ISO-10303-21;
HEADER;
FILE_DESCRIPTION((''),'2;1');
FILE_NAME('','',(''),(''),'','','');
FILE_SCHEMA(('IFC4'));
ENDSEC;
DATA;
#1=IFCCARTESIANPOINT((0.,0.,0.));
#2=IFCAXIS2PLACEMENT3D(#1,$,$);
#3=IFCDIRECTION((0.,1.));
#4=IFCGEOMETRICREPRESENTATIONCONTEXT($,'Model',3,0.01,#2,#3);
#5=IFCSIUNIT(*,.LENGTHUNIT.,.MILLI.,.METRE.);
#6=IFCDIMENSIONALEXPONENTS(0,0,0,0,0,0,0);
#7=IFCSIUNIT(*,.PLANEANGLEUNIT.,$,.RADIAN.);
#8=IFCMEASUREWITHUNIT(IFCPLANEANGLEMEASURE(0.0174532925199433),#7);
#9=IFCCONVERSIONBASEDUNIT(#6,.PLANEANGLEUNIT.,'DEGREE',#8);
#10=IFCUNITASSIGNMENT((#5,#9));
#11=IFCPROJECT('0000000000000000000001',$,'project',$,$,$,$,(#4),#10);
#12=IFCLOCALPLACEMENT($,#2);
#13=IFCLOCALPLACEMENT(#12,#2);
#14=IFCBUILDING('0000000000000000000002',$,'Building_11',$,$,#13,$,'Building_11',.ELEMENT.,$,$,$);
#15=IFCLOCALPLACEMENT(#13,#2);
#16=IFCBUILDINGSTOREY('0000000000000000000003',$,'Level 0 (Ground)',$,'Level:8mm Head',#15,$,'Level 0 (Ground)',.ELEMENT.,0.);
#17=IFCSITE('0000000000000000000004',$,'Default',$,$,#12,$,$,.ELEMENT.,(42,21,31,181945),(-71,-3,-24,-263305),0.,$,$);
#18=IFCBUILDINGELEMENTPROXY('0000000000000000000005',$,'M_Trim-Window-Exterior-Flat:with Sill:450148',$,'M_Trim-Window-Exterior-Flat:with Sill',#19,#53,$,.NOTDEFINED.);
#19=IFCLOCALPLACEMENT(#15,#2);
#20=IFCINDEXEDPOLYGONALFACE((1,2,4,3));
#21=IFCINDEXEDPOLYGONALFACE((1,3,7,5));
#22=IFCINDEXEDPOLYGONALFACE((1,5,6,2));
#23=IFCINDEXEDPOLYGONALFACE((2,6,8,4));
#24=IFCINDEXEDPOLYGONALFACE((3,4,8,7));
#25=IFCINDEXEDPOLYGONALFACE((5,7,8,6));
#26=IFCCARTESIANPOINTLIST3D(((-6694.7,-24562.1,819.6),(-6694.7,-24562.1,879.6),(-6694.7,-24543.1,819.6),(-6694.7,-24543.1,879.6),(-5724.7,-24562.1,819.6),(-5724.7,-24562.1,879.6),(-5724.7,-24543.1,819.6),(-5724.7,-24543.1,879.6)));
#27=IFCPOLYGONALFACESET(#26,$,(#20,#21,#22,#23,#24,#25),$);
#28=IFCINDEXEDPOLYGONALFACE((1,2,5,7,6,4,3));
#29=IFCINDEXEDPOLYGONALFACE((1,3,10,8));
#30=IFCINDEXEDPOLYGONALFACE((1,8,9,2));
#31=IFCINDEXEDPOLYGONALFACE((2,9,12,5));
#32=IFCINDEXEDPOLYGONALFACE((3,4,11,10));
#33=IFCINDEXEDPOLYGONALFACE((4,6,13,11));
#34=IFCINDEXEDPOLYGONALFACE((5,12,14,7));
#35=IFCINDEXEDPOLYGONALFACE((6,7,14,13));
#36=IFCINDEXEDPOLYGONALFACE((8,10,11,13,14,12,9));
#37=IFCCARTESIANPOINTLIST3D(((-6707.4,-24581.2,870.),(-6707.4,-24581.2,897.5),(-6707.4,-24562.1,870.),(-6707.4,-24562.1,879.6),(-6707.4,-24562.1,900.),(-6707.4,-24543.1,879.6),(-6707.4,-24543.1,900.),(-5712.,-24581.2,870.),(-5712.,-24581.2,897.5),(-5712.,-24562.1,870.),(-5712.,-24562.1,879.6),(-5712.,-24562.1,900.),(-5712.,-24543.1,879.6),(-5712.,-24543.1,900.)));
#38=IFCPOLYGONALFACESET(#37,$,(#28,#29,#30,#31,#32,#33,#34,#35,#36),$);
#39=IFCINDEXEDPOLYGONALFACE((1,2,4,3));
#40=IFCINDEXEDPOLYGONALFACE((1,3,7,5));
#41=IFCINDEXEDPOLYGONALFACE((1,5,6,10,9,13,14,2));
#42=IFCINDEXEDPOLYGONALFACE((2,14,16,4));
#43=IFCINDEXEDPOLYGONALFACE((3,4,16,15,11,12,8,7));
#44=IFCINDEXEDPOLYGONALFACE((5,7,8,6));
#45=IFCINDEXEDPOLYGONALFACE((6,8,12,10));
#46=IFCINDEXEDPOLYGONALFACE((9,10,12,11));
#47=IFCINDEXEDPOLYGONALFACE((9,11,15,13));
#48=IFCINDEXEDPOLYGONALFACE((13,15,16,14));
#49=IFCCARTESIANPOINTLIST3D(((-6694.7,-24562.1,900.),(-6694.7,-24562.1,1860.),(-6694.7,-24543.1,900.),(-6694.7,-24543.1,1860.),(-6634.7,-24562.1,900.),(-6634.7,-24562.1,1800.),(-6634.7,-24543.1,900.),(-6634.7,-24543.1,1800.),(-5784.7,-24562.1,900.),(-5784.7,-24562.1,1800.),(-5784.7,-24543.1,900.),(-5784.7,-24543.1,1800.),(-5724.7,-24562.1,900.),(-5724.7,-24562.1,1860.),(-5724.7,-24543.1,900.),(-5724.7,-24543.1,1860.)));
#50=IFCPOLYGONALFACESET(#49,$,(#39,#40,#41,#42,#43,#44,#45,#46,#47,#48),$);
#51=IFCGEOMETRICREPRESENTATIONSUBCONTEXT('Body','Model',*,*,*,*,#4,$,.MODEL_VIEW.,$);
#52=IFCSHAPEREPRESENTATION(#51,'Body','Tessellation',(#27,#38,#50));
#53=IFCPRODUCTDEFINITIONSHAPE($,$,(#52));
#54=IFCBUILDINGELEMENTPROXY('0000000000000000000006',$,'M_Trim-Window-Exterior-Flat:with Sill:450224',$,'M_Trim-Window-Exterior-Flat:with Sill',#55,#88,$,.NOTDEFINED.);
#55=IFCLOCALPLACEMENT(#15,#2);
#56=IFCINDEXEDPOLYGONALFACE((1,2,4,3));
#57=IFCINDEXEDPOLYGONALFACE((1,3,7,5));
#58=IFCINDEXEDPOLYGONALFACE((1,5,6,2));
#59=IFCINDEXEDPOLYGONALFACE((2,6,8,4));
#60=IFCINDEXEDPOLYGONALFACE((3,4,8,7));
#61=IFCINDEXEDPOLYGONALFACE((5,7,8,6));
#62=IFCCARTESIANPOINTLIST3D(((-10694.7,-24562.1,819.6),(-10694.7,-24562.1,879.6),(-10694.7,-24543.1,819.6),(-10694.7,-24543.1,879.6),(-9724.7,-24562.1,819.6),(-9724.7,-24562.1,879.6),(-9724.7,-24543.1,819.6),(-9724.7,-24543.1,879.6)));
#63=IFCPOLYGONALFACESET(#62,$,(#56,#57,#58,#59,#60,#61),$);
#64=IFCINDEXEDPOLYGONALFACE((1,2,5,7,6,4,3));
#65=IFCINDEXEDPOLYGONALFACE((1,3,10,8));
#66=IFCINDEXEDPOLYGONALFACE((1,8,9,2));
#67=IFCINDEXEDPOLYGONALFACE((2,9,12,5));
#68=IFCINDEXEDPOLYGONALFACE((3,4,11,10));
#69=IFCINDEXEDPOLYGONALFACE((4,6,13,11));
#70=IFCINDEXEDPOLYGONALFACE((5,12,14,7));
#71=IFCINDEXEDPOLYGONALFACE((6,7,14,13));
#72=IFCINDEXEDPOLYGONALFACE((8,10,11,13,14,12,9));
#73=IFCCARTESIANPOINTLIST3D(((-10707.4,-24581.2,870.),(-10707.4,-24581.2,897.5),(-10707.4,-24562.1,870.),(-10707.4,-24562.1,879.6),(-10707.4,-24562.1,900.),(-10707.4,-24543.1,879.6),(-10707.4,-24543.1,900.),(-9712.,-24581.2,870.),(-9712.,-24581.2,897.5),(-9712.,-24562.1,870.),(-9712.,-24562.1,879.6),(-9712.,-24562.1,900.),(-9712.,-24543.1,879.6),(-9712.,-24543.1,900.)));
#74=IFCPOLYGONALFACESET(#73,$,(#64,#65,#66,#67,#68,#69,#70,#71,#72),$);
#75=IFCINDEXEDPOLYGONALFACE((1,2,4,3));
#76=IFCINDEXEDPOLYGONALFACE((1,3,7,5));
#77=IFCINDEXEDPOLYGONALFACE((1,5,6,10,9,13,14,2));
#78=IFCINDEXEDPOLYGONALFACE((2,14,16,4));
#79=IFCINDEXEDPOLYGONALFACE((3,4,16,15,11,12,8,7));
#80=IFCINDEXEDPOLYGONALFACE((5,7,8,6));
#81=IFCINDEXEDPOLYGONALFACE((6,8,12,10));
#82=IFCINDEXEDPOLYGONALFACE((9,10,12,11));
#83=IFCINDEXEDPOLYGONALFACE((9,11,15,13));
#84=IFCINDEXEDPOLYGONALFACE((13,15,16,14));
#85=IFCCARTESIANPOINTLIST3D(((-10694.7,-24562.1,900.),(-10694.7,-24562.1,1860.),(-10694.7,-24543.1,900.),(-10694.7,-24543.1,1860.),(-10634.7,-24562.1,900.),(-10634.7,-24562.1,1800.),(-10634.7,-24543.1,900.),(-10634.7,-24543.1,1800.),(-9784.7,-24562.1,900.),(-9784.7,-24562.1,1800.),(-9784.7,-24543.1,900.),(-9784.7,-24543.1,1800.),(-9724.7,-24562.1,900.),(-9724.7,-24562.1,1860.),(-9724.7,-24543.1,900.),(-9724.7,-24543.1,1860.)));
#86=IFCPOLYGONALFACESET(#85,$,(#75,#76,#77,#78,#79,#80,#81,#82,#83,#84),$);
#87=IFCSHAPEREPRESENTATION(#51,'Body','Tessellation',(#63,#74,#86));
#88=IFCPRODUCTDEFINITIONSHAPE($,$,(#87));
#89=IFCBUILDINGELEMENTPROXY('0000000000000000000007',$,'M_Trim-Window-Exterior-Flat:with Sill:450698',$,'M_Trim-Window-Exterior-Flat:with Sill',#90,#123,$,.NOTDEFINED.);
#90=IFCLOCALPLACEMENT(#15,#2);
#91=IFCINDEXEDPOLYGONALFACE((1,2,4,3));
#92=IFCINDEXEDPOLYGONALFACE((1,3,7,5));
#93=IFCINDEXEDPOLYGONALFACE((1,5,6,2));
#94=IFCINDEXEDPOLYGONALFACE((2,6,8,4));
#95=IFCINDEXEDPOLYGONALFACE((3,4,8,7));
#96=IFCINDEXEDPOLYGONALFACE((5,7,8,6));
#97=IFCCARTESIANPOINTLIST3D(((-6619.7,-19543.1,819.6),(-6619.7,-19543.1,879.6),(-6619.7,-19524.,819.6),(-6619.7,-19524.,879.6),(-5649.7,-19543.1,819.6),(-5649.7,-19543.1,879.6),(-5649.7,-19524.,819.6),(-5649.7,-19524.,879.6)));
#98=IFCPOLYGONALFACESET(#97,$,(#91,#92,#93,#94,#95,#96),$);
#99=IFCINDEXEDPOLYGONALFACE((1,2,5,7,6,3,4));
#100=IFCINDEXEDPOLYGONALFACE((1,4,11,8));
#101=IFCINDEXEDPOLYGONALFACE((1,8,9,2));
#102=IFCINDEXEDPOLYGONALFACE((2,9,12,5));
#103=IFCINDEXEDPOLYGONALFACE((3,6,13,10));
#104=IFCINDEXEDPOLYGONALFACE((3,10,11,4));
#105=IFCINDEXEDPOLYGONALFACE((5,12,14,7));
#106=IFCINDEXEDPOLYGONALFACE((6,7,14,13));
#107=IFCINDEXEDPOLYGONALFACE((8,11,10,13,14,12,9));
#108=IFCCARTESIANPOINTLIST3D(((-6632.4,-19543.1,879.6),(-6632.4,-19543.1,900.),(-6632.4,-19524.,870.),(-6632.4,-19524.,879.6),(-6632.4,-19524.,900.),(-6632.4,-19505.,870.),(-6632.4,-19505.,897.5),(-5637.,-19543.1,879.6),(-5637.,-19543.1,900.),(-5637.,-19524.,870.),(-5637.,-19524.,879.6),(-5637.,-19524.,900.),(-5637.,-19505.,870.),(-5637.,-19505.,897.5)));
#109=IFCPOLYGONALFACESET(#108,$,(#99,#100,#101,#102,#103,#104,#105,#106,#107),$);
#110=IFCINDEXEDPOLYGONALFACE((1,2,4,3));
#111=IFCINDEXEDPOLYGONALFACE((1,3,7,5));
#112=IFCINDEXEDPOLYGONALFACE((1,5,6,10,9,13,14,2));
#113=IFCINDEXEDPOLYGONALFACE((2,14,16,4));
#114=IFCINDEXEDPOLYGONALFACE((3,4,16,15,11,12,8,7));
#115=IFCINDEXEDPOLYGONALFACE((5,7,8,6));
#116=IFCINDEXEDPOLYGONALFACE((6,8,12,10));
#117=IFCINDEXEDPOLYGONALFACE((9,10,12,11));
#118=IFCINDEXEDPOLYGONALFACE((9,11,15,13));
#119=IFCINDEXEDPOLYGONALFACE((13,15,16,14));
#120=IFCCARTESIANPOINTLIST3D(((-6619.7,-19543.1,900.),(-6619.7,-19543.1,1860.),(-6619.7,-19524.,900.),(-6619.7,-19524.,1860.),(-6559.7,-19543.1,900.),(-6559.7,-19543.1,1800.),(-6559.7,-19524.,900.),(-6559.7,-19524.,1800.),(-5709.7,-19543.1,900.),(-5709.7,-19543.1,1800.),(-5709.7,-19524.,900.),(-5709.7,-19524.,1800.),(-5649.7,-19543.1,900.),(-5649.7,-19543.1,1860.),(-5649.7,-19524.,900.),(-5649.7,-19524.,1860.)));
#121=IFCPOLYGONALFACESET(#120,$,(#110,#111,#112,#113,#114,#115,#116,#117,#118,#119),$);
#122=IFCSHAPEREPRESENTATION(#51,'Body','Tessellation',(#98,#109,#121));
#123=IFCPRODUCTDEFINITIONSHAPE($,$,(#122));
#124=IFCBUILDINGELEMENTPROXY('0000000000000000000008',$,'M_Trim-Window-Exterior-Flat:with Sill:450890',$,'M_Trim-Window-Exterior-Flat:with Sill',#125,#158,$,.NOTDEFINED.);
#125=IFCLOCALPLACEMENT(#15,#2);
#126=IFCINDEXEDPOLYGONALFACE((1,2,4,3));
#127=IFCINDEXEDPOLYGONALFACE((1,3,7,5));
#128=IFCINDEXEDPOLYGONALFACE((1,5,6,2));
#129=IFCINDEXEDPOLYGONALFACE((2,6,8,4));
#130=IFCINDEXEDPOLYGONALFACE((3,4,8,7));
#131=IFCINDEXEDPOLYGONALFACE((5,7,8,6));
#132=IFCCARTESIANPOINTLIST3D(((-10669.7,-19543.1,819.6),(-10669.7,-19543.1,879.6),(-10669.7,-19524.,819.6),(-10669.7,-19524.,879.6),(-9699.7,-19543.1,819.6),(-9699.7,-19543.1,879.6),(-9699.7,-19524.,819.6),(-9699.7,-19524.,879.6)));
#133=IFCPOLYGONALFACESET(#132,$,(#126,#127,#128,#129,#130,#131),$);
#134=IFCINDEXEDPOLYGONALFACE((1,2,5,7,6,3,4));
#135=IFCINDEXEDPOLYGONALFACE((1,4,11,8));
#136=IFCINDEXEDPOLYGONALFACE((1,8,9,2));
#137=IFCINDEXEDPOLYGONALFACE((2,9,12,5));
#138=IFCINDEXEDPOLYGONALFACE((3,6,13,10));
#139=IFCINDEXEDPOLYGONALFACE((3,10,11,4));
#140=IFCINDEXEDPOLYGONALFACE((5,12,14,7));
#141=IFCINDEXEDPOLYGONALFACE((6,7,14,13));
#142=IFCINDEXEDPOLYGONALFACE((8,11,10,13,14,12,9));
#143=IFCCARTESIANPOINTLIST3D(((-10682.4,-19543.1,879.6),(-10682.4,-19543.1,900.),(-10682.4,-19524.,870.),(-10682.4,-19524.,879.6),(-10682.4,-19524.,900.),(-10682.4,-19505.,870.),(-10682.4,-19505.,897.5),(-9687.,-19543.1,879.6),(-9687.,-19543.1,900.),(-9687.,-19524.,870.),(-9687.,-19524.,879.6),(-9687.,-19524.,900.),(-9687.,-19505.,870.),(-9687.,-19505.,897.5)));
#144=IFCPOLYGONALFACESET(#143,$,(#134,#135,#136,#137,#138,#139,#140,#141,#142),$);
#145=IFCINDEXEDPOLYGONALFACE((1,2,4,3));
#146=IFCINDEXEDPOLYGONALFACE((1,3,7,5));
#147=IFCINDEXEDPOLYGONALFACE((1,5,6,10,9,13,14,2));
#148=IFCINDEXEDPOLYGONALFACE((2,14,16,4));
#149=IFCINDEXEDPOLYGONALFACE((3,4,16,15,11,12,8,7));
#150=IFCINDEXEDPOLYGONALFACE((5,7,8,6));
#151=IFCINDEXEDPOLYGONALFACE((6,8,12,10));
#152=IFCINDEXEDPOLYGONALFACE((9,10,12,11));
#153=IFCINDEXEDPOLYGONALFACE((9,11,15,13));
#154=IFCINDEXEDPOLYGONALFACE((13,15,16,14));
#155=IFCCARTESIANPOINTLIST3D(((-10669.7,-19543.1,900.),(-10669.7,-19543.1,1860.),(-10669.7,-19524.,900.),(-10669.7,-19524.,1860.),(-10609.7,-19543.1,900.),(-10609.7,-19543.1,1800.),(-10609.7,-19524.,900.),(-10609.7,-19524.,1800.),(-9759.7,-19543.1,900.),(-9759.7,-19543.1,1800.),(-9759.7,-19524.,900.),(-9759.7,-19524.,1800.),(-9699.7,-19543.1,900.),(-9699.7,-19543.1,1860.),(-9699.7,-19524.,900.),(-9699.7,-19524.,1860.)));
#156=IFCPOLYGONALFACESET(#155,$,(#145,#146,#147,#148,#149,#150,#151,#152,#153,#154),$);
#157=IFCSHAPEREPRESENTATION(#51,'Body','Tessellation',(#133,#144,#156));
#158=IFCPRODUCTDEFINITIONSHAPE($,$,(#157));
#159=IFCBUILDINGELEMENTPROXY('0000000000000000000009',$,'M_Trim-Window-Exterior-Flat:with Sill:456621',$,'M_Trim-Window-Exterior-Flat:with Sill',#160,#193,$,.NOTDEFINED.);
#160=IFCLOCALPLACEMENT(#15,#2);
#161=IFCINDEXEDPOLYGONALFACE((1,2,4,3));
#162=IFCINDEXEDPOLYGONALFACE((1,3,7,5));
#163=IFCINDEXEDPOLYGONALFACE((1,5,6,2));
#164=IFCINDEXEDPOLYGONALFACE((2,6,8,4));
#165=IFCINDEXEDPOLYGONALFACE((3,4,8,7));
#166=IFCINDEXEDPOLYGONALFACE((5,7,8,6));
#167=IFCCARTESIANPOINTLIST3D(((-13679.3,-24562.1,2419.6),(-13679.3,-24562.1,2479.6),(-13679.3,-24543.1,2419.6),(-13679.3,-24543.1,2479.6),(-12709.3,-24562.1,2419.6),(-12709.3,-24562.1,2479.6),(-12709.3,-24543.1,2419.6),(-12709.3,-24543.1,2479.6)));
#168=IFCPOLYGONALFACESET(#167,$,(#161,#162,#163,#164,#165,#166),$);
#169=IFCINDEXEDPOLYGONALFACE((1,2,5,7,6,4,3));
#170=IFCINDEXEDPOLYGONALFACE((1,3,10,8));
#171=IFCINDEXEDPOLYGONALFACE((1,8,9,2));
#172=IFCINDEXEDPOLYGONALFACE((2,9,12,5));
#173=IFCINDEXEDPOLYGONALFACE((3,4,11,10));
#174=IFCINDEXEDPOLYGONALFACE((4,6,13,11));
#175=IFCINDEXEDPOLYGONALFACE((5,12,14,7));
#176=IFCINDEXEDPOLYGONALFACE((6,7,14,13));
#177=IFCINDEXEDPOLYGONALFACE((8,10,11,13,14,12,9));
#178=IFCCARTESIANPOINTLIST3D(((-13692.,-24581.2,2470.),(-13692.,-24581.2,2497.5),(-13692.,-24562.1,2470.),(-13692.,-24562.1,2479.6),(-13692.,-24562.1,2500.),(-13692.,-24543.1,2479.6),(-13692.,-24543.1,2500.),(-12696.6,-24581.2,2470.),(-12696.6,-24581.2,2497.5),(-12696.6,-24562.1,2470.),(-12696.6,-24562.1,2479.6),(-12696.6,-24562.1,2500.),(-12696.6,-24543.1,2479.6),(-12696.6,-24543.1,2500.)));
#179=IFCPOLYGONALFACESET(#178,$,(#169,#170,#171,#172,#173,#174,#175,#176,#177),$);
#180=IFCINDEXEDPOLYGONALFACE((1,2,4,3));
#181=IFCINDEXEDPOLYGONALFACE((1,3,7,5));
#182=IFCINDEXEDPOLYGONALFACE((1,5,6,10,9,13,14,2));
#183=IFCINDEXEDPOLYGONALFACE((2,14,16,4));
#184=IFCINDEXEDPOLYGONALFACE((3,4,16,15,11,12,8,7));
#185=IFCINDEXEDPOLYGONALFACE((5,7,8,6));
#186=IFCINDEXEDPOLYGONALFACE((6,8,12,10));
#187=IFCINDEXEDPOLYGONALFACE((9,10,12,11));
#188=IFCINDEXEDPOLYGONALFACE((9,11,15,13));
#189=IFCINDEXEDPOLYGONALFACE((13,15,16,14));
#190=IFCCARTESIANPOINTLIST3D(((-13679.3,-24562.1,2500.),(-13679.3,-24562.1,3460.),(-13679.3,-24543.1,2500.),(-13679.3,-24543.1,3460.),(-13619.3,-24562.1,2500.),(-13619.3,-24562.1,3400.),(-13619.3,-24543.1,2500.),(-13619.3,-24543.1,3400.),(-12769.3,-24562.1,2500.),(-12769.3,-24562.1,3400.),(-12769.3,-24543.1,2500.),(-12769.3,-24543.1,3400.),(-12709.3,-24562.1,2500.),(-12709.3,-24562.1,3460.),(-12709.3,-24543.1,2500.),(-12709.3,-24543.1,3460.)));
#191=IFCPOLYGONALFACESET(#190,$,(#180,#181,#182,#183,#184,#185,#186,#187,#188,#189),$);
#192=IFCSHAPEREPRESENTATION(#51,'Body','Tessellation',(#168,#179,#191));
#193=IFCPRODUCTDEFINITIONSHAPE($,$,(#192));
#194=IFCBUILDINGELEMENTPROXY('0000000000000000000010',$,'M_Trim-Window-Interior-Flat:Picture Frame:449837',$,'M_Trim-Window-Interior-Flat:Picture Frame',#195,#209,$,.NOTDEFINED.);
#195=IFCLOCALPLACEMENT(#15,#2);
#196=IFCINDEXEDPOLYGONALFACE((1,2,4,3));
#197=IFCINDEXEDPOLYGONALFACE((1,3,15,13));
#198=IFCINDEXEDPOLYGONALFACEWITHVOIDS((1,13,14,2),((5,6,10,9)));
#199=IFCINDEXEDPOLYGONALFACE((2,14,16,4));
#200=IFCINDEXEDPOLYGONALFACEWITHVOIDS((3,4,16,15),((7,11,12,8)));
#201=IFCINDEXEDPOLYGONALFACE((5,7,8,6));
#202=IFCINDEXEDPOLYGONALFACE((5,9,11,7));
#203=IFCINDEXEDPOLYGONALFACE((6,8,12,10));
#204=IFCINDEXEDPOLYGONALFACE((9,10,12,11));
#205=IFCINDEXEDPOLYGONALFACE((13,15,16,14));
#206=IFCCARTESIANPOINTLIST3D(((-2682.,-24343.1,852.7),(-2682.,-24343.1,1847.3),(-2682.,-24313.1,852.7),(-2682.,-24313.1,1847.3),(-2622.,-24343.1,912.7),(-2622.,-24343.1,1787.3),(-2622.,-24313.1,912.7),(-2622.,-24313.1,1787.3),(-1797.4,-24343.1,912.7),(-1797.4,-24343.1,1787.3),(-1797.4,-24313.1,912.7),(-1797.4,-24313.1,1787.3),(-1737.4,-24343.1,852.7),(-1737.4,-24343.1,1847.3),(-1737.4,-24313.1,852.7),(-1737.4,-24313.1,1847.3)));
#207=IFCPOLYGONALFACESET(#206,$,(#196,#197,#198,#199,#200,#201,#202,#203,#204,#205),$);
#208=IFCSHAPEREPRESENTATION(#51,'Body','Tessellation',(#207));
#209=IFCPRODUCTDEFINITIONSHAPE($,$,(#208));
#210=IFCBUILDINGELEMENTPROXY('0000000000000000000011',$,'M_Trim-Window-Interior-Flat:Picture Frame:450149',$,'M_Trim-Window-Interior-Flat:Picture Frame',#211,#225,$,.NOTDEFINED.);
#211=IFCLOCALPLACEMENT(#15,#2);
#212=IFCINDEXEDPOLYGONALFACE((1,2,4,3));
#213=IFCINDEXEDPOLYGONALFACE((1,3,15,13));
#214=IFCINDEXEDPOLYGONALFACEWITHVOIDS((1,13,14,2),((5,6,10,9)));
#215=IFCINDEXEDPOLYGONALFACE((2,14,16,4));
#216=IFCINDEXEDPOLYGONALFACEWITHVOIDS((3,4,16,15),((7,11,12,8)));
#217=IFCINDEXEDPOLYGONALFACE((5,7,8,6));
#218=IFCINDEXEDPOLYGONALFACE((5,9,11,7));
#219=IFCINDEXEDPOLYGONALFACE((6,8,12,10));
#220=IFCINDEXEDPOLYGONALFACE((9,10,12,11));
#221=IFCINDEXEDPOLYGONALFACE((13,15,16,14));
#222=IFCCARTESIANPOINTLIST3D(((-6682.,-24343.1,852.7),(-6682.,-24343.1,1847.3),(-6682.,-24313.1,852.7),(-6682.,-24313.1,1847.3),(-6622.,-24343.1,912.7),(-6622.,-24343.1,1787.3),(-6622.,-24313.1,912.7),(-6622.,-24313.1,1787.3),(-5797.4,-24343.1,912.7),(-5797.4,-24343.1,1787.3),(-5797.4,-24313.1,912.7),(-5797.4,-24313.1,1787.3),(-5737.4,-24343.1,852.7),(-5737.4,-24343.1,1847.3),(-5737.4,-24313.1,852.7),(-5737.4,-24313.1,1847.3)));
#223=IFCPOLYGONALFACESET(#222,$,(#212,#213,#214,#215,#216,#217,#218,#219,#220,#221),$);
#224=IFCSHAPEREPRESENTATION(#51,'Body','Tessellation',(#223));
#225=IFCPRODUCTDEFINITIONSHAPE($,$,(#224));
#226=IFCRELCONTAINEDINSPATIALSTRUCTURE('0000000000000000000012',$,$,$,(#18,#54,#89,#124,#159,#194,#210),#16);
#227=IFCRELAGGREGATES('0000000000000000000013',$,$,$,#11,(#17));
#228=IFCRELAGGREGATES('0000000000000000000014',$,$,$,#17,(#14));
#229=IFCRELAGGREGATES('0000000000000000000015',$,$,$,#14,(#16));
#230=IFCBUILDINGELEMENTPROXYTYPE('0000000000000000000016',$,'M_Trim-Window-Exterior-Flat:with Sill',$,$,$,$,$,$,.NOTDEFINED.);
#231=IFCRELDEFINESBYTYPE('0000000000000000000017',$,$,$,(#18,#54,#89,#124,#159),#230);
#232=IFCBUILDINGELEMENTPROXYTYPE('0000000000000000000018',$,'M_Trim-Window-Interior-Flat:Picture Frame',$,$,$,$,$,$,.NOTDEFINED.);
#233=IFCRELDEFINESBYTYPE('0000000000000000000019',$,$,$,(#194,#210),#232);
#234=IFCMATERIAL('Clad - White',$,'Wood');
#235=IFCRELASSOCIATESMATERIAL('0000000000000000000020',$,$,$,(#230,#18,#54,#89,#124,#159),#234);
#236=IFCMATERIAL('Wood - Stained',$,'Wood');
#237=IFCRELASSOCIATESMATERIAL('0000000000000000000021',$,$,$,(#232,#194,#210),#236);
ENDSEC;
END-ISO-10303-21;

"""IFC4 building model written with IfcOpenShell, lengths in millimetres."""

from ifc_helpers import new_model, entity, si_unit, converted_unit, direction, frame, origin, place, context, subcontext, project, spatial, indexed_curve, outline, extrude, source, transform, mapped, material, type_object, type_shapes, element, save


model = new_model("IFC4")

# Units and contexts
model_context = context("Model", 3, precision=0.01, world=origin(), true_north=direction((0.0, 1.0)))
body_context = subcontext(model_context, "Body", "Model", "MODEL_VIEW")
ifc_project = project(units=[si_unit("LENGTHUNIT", "METRE", prefix="MILLI"), converted_unit("PLANEANGLEUNIT", "DEGREE", entity("IfcPlaneAngleMeasure", 0.0174532925199433), si_unit("PLANEANGLEUNIT", "RADIAN"), dimensions=[0, 0, 0, 0, 0, 0, 0])], contexts=[model_context])

# Site, building, storey
site_placement = place(None, origin())
site = spatial("IfcSite", under=ifc_project, at=site_placement, Name="Default", CompositionType="ELEMENT", RefLatitude=(42, 21, 31, 181945), RefLongitude=(-71, -3, -24, -263305), RefElevation=0.0)
building_placement = place(site_placement, origin())
building = spatial("IfcBuilding", under=site, at=building_placement, Name="Building_11", LongName="Building_11", CompositionType="ELEMENT")
storey_placement = place(building_placement, origin())
storey = spatial("IfcBuildingStorey", under=building, at=storey_placement, Name="Level 0 (Ground)", ObjectType="Level:8mm Head", LongName="Level 0 (Ground)", CompositionType="ELEMENT", Elevation=0.0)

# Building element proxies
ifc_material_1 = material(Name="Clad - White", Category="Wood")
building_element_proxy_type_1 = type_object("IfcBuildingElementProxyType", Name="M_Trim-Window-Exterior-Flat:with Sill", PredefinedType="NOTDEFINED", material=ifc_material_1)
shared_shape_1 = source(origin(), body_context, "Body", "SweptSolid", [
    extrude(outline(indexed_curve([(-485.0, -30.0), (485.0, -30.0), (485.0, 30.0), (-485.0, 30.0), (-485.0, -30.0)], self_intersect=False)), frame((0.0, -950.4, 0.0), z_axis=(0.0, 0.0, 1.0), x_axis=(-1.0, 0.0, 0.0)), (0.0, 0.0, 1.0), 19.1),
    extrude(outline(indexed_curve([(-19.0, -15.2), (0.0, -15.2), (0.0, -5.7), (19.0, -5.7), (19.0, 14.8), (0.0, 14.8), (-19.0, 12.3), (-19.0, -15.2)], self_intersect=False)), frame((-497.7, -914.8, 19.0), z_axis=(1.0, 0.0, 0.0), x_axis=(0.0, 0.0, -1.0)), (0.0, 0.0, 1.0), 995.4),
    extrude(outline(indexed_curve([(-495.0, -485.0), (465.0, -485.0), (465.0, -425.0), (-435.0, -425.0), (-435.0, 425.0), (465.0, 425.0), (465.0, 485.0), (-495.0, 485.0), (-495.0, -485.0)], self_intersect=False)), frame((0.0, -435.0, 0.0), z_axis=(0.0, 0.0, 1.0), x_axis=(0.0, -1.0, 0.0)), (0.0, 0.0, 1.0), 19.1),
])
type_shapes(building_element_proxy_type_1, [shared_shape_1])
for number, where, z_axis, x_axis, name in (
    (1, (-6209.7, -24543.1, 1800.0), (0.0, -1.0, 0.0), (1.0, 0.0, 0.0), "M_Trim-Window-Exterior-Flat:with Sill:450148"),
    (2, (-10209.7, -24543.1, 1800.0), (0.0, -1.0, 0.0), (1.0, 0.0, 0.0), "M_Trim-Window-Exterior-Flat:with Sill:450224"),
    (3, (-6134.7, -19543.1, 1800.0), (0.0, 1.0, 0.0), (-1.0, 0.0, 0.0), "M_Trim-Window-Exterior-Flat:with Sill:450698"),
    (4, (-10184.7, -19543.1, 1800.0), (0.0, 1.0, 0.0), (-1.0, 0.0, 0.0), "M_Trim-Window-Exterior-Flat:with Sill:450890"),
    (5, (-13194.3, -24543.1, 3400.0), (0.0, -1.0, 0.0), (1.0, 0.0, 0.0), "M_Trim-Window-Exterior-Flat:with Sill:456621"),
):
    element("IfcBuildingElementProxy", number, at=place(storey_placement, frame(where, z_axis=z_axis, x_axis=x_axis)), inside=storey, type_object=building_element_proxy_type_1, material=ifc_material_1, Name=name, ObjectType="M_Trim-Window-Exterior-Flat:with Sill", PredefinedType="NOTDEFINED", context=body_context, shape_type="MappedRepresentation", body=[
        mapped(shared_shape_1, transform((0.0, 0.0, 0.0), scale=1.0)),
    ])
ifc_material_2 = material(Name="Wood - Stained", Category="Wood")
building_element_proxy_type_2 = type_object("IfcBuildingElementProxyType", Name="M_Trim-Window-Interior-Flat:Picture Frame", PredefinedType="NOTDEFINED", material=ifc_material_2)
shared_shape_2 = source(origin(), body_context, "Body", "SweptSolid", [
    extrude(outline(indexed_curve([(-472.3, -497.3), (472.3, -497.3), (472.3, 497.3), (-472.3, 497.3), (-472.3, -497.3)], self_intersect=False), holes=[indexed_curve([(-412.3, -437.3), (-412.3, 437.3), (412.3, 437.3), (412.3, -437.3), (-412.3, -437.3)], self_intersect=False)]), frame((0.0, -450.0, 0.0), z_axis=(0.0, 0.0, 1.0), x_axis=(-1.0, 0.0, 0.0)), (0.0, 0.0, 1.0), 30.0),
])
type_shapes(building_element_proxy_type_2, [shared_shape_2])
for number, where, z_axis, x_axis, name in (
    (6, (-2209.7, -24343.1, 1800.0), (0.0, 1.0, 0.0), (-1.0, 0.0, 0.0), "M_Trim-Window-Interior-Flat:Picture Frame:449837"),
    (7, (-6209.7, -24343.1, 1800.0), (0.0, 1.0, 0.0), (-1.0, 0.0, 0.0), "M_Trim-Window-Interior-Flat:Picture Frame:450149"),
):
    element("IfcBuildingElementProxy", number, at=place(storey_placement, frame(where, z_axis=z_axis, x_axis=x_axis)), inside=storey, type_object=building_element_proxy_type_2, material=ifc_material_2, Name=name, ObjectType="M_Trim-Window-Interior-Flat:Picture Frame", PredefinedType="NOTDEFINED", context=body_context, shape_type="MappedRepresentation", body=[
        mapped(shared_shape_2, transform((0.0, 0.0, 0.0), scale=1.0)),
    ])

save(model, "model.ifc")
